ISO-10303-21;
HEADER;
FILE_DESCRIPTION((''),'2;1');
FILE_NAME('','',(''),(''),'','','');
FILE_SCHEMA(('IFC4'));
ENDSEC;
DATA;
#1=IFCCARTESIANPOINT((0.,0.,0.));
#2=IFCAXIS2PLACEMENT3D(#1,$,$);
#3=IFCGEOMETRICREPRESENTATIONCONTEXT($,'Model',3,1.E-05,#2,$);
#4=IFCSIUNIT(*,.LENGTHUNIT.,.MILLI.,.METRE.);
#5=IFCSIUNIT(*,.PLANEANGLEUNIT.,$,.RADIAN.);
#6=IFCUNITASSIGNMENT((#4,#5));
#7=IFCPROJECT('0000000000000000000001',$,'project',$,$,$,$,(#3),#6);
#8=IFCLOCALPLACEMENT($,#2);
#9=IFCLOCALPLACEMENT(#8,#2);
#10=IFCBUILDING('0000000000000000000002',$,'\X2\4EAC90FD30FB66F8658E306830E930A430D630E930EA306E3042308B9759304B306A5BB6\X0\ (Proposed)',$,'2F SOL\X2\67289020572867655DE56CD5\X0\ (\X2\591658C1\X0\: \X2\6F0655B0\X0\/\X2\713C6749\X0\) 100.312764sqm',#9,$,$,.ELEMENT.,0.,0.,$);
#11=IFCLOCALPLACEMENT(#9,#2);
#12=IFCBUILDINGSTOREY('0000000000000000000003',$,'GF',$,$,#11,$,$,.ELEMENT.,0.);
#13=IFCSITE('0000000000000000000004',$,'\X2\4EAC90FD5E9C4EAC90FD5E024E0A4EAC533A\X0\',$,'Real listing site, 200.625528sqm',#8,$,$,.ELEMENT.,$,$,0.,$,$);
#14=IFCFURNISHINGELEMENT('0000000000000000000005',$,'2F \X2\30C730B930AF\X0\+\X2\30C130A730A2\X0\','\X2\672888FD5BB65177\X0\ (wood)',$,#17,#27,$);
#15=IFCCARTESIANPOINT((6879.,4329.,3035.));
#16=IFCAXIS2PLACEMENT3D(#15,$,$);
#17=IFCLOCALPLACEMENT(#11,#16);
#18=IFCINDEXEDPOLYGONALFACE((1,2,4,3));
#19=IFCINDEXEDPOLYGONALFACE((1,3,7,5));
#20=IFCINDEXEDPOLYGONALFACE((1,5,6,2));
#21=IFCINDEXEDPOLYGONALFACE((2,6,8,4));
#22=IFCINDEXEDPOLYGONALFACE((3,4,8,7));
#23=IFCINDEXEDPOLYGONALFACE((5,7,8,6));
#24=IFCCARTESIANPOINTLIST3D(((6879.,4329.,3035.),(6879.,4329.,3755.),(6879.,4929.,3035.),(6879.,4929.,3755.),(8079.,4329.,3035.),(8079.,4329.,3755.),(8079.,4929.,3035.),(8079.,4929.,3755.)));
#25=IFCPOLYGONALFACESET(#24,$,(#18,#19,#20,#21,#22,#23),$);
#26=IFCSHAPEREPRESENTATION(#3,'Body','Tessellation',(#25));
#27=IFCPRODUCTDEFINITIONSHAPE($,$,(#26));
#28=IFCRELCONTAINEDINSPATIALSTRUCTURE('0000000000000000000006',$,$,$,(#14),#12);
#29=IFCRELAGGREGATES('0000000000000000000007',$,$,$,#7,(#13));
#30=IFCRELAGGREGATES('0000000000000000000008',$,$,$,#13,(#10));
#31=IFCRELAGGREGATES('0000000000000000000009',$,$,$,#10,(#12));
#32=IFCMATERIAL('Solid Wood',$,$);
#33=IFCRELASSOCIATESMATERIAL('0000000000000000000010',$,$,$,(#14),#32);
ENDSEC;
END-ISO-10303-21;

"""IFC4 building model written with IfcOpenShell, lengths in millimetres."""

from ifc_helpers import new_model, si_unit, frame, frame_2d, origin, place, context, project, spatial, rectangle, extrude, material, element, save


model = new_model("IFC4")

# Units and contexts
model_context = context("Model", 3, precision=1e-05, world=origin())
ifc_project = project(units=[si_unit("LENGTHUNIT", "METRE", prefix="MILLI"), si_unit("PLANEANGLEUNIT", "RADIAN")], contexts=[model_context])

# Site, building, storey
site_placement = place(None, origin())
site = spatial("IfcSite", under=ifc_project, at=site_placement, Name="京都府京都市上京区", ObjectType="Real listing site, 200.625528sqm", CompositionType="ELEMENT", RefElevation=0.0)
building_placement = place(site_placement, origin())
building = spatial("IfcBuilding", under=site, at=building_placement, Name="京都・書斎とライブラリのある静かな家 (Proposed)", ObjectType="2F SOL木造在来工法 (外壁: 漆喰/焼杉) 100.312764sqm", CompositionType="ELEMENT", ElevationOfRefHeight=0.0, ElevationOfTerrain=0.0)
storey_placement = place(building_placement, origin())
storey = spatial("IfcBuildingStorey", under=building, at=storey_placement, Name="GF", CompositionType="ELEMENT", Elevation=0.0)

# Shared definitions
ifc_material_1 = material(Name="Solid Wood")

# Furnishing element
furnishing_1_placement = place(storey_placement, frame((6879.0, 4329.0, 3035.0)))
element("IfcFurnishingElement", 1, at=furnishing_1_placement, inside=storey, material=ifc_material_1, Name="2F デスク+チェア", Description="木製家具 (wood)", context=model_context, shape_type="SweptSolid", body=[
    extrude(rectangle(XDim=1200.0, YDim=600.0, at=frame_2d((600.0, 300.0))), frame((6879.0, 4329.0, 3035.0)), (0.0, 0.0, 1.0), 720.0),
])

save(model, "model.ifc")
